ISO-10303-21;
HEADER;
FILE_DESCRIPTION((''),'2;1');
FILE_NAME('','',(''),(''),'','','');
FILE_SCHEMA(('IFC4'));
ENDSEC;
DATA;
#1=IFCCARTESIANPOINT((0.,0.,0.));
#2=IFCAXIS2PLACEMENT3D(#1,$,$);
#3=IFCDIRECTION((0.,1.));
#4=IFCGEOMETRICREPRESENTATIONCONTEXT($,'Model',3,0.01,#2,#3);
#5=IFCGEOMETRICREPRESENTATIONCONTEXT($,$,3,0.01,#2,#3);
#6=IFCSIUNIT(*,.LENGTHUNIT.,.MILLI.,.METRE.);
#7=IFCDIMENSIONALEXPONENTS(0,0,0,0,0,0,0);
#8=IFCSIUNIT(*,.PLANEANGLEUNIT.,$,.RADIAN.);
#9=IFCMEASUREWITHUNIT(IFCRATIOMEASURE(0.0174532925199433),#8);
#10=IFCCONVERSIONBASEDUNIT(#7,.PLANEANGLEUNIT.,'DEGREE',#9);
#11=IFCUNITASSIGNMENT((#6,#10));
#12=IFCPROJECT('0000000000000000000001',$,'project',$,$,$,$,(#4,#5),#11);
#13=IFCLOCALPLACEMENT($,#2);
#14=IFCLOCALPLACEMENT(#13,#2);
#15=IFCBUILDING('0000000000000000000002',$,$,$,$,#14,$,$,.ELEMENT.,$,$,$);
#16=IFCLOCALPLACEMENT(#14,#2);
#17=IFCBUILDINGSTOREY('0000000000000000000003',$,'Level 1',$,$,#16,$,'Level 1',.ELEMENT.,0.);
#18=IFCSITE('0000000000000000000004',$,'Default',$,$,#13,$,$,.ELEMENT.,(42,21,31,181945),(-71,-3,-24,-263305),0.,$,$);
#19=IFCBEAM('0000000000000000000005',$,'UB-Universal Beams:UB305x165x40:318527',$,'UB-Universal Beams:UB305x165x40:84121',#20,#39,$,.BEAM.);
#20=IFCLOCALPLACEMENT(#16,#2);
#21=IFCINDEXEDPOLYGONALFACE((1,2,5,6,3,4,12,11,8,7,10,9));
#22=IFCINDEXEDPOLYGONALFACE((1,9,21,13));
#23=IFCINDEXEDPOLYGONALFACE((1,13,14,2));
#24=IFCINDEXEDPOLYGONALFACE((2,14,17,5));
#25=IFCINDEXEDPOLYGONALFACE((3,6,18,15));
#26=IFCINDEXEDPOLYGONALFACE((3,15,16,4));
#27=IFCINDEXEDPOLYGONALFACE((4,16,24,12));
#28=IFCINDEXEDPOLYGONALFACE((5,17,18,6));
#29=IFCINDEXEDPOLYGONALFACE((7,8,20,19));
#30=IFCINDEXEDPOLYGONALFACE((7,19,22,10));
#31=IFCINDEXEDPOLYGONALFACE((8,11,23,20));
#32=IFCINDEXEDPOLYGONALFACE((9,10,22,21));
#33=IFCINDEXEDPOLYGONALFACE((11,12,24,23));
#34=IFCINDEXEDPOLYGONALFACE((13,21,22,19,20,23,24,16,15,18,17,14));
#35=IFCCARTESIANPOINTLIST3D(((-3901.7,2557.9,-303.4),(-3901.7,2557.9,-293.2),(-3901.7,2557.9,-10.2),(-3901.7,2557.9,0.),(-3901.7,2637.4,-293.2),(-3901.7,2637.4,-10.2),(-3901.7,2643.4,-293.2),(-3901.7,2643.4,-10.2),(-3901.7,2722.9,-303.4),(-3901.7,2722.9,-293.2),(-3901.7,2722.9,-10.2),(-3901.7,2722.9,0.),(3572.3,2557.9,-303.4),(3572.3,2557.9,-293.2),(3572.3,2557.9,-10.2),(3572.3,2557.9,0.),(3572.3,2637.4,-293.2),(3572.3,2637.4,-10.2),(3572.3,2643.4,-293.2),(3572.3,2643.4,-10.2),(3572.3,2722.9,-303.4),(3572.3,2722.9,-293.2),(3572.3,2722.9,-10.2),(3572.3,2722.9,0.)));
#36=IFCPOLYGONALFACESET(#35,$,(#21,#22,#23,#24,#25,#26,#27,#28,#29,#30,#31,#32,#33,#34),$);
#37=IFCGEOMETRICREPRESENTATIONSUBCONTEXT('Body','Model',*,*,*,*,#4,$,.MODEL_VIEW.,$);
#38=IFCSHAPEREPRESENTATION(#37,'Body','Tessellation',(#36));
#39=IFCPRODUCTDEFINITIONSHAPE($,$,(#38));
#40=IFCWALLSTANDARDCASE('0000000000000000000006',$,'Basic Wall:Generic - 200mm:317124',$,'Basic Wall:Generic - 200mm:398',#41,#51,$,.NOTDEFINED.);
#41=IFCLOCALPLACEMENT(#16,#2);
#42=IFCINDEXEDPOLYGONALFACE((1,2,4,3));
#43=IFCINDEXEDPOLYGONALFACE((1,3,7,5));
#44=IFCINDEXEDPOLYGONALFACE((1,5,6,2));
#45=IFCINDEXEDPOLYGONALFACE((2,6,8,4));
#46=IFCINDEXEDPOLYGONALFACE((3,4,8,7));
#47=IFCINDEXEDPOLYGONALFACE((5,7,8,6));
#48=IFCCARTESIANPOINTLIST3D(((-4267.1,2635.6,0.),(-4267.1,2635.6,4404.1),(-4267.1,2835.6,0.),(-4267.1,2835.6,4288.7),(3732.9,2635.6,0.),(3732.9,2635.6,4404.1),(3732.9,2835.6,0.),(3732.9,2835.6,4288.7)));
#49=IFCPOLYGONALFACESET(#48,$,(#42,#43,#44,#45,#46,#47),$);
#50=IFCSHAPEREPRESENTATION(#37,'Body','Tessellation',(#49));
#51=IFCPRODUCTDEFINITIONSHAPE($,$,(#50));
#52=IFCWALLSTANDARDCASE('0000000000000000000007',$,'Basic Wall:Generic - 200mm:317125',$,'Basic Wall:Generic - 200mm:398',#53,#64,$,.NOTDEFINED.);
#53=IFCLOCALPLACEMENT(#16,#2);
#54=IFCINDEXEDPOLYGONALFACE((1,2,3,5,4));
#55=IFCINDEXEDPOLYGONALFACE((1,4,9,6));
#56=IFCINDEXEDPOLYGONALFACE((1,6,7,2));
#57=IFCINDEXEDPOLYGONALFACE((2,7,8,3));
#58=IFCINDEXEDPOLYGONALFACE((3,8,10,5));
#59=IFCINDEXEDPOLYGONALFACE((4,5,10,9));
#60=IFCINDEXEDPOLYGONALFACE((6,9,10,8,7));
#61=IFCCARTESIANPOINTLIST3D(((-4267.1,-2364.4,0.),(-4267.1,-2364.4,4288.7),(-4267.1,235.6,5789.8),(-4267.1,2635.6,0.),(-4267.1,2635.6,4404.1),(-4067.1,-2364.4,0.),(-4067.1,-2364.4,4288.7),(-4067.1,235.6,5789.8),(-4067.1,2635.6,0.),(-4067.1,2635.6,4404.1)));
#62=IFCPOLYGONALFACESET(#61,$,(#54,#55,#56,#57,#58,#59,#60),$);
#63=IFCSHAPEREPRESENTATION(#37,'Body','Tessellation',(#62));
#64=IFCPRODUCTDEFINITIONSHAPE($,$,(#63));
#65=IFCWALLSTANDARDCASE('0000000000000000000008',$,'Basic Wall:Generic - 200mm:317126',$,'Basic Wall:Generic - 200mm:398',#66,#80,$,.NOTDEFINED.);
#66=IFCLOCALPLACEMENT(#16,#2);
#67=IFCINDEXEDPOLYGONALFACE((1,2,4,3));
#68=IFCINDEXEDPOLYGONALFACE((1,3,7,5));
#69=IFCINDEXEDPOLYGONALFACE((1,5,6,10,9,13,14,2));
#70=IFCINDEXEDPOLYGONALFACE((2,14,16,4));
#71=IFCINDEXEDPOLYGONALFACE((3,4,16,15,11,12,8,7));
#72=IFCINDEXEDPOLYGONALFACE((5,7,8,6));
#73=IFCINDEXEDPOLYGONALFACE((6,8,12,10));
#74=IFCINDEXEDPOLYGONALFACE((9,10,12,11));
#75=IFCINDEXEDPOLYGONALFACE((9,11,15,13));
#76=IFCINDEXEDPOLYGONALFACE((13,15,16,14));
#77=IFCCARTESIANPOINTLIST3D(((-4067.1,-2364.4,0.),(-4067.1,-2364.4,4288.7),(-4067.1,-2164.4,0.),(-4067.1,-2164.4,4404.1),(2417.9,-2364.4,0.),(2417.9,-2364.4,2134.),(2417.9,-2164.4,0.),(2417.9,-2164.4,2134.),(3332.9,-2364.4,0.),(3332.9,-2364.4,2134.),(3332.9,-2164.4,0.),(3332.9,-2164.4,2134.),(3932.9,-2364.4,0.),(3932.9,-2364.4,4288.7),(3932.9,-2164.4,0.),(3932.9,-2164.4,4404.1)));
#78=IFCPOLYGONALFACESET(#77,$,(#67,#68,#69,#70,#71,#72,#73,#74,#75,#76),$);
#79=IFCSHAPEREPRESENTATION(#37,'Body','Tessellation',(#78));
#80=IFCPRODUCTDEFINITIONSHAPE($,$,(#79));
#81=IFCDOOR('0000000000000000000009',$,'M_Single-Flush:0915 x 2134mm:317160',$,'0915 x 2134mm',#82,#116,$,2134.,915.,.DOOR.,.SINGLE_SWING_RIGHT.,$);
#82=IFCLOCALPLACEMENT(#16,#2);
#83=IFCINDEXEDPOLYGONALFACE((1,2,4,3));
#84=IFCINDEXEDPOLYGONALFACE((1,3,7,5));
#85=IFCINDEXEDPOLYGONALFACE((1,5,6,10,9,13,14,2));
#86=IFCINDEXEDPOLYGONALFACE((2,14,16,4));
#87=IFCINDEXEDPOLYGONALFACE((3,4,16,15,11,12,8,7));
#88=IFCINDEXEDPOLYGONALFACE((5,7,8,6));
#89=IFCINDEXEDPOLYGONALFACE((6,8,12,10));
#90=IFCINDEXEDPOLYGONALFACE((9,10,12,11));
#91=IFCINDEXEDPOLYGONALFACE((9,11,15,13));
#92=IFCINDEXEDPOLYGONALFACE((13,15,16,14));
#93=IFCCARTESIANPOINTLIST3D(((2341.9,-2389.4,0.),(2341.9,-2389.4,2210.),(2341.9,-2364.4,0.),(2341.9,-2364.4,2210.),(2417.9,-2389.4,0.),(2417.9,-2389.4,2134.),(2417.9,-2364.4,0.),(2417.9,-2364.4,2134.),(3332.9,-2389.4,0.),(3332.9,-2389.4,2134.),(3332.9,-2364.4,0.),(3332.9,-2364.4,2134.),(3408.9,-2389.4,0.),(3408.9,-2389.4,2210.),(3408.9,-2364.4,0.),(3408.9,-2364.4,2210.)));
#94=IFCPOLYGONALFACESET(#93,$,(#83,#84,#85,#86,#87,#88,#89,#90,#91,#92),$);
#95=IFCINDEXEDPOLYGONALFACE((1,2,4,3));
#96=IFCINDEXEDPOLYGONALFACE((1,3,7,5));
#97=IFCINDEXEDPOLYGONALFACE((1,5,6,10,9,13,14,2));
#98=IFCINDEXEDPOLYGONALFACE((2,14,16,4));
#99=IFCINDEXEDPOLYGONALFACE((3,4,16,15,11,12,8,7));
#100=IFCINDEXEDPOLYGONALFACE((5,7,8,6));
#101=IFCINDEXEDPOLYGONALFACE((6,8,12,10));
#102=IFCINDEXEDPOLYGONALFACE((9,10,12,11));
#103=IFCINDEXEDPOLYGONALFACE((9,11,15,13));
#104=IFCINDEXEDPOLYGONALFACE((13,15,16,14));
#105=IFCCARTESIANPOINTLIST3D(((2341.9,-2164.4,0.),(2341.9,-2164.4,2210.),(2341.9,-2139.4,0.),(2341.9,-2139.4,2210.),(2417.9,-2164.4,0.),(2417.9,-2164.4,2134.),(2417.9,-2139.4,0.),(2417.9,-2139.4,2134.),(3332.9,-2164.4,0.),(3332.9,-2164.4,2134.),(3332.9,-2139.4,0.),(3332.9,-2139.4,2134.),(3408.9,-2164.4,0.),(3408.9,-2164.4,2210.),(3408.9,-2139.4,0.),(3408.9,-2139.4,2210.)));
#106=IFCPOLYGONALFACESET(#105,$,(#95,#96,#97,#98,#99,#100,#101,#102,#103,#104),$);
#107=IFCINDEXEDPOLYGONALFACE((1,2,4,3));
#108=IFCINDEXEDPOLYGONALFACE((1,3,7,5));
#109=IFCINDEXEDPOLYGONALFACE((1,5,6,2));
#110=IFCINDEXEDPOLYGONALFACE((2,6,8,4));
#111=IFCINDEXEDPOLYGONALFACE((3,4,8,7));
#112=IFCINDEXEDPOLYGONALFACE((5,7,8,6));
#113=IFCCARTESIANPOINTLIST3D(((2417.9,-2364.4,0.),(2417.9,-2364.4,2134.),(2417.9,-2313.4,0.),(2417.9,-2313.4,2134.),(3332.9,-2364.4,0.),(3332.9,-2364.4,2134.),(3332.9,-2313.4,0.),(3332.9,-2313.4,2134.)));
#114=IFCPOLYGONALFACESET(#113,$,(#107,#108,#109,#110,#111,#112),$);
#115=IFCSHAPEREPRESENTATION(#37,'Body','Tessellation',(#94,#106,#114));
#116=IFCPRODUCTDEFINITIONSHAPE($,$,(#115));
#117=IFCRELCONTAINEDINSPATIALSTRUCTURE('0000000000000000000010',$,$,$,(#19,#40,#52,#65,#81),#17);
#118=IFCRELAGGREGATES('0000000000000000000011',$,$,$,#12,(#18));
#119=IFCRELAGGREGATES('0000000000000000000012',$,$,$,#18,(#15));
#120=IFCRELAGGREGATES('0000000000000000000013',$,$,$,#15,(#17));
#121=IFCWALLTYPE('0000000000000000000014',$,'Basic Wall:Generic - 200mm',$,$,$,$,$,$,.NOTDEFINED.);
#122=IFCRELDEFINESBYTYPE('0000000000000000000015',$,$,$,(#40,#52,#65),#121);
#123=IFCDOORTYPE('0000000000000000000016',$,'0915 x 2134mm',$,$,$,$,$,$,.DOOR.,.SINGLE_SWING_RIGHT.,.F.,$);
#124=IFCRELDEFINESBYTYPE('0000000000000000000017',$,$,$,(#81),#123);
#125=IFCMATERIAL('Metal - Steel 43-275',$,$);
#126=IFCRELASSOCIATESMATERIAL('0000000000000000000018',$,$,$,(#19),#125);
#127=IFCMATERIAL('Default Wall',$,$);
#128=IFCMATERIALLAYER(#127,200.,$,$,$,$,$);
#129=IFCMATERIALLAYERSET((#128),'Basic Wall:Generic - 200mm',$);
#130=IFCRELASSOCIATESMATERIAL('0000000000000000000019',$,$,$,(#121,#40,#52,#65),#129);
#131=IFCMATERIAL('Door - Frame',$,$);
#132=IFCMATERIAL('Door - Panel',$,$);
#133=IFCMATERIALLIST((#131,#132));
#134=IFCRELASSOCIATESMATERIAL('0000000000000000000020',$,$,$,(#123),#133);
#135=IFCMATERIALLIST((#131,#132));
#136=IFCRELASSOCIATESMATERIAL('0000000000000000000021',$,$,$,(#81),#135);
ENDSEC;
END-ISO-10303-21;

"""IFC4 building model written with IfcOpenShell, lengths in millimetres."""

from ifc_helpers import new_model, entity, si_unit, converted_unit, direction, frame, frame_2d, origin, place, context, subcontext, project, spatial, polyline, rectangle, i_section, outline, extrude, clip, bounded_halfspace, source, transform, mapped, material, material_list, layer, layer_set, layer_usage, type_object, type_shapes, element, fill, save


model = new_model("IFC4")

# Units and contexts
model_context = context("Model", 3, precision=0.01, world=origin(), true_north=direction((0.0, 1.0)))
context_of_model = context(None, 3, precision=0.01, world=origin(), true_north=direction((0.0, 1.0)))
body_context = subcontext(model_context, "Body", "Model", "MODEL_VIEW")
ifc_project = project(units=[si_unit("LENGTHUNIT", "METRE", prefix="MILLI"), converted_unit("PLANEANGLEUNIT", "DEGREE", entity("IfcRatioMeasure", 0.0174532925199433), si_unit("PLANEANGLEUNIT", "RADIAN"), dimensions=[0, 0, 0, 0, 0, 0, 0])], contexts=[model_context, context_of_model])

# Site, building, storey
site_placement = place(None, origin())
site = spatial("IfcSite", under=ifc_project, at=site_placement, Name="Default", CompositionType="ELEMENT", RefLatitude=(42, 21, 31, 181945), RefLongitude=(-71, -3, -24, -263305), RefElevation=0.0)
building_placement = place(site_placement, origin())
building = spatial("IfcBuilding", under=site, at=building_placement, CompositionType="ELEMENT")
storey_placement = place(building_placement, origin())
storey = spatial("IfcBuildingStorey", under=building, at=storey_placement, Name="Level 1", LongName="Level 1", CompositionType="ELEMENT", Elevation=0.0)

# Shared definitions
ifc_material_1 = material(Name="Metal - Steel 43-275")

# Beam
beam_1_placement = place(storey_placement, frame((-4067.1, 2640.4, 0.0)))
element("IfcBeam", 1, at=beam_1_placement, inside=storey, material=ifc_material_1, Name="UB-Universal Beams:UB305x165x40:318527", ObjectType="UB-Universal Beams:UB305x165x40:84121", PredefinedType="BEAM", context=body_context, shape_type="SweptSolid", body=[
    extrude(i_section(OverallWidth=165.0, OverallDepth=303.4, WebThickness=6.0, FlangeThickness=10.2, at=frame_2d((0.0, 0.0), x_axis=(0.0, 1.0))), frame((165.4, 0.0, -151.7), z_axis=(1.0, 0.0, 0.0), x_axis=(0.0, 0.0, -1.0)), (0.0, 0.0, 1.0), 7474.0),
])

# Walls
ifc_material_2 = material(Name="Default Wall")
ifc_layer = layer(ifc_material_2, 200.0)
ifc_layer_set = layer_set([ifc_layer], Name="Basic Wall:Generic - 200mm")
ifc_layer_usage_1 = layer_usage(ifc_layer_set, "AXIS2", "NEGATIVE", 100.0)
wall_type = type_object("IfcWallType", Name="Basic Wall:Generic - 200mm", PredefinedType="NOTDEFINED", material=ifc_layer_set)
wall_1_placement = place(storey_placement, frame((-4267.1, 2735.6, 0.0)))
element("IfcWallStandardCase", 2, at=wall_1_placement, inside=storey, type_object=wall_type, material=ifc_layer_usage_1, Name="Basic Wall:Generic - 200mm:317124", ObjectType="Basic Wall:Generic - 200mm:398", PredefinedType="NOTDEFINED", context=body_context, shape_type="Clipping", body=[
    clip(extrude(rectangle(XDim=8000.0, YDim=200.0, at=frame_2d((4000.0, 0.0), x_axis=(-1.0, 0.0))), origin(), (0.0, 0.0, 1.0), 4404.1), bounded_halfspace(frame((0.0, -100.0, 4404.1), z_axis=(0.0, 0.5, 0.866025), x_axis=(-1.0, 0.0, 0.0)), False, frame((0.0, -100.0, 4404.1)), polyline([(0.0, 0.0), (200.0, 0.0), (8000.0, 0.0), (8000.0, 200.0), (0.0, 200.0), (0.0, 0.0)]))),
])
ifc_layer_usage_2 = layer_usage(ifc_layer_set, "AXIS2", "NEGATIVE", 100.0)
wall_2_placement = place(storey_placement, frame((-4167.1, -2364.4, 0.0), z_axis=(0.0, 0.0, 1.0), x_axis=(0.0, 1.0, 0.0)))
element("IfcWallStandardCase", 3, at=wall_2_placement, inside=storey, type_object=wall_type, material=ifc_layer_usage_2, Name="Basic Wall:Generic - 200mm:317125", ObjectType="Basic Wall:Generic - 200mm:398", PredefinedType="NOTDEFINED", context=body_context, shape_type="Clipping", body=[
    clip(clip(extrude(rectangle(XDim=5000.0, YDim=200.0, at=frame_2d((2500.0, 0.0), x_axis=(-1.0, 0.0))), origin(), (0.0, 0.0, 1.0), 5789.8), bounded_halfspace(frame((2600.0, -100.0, 5789.8), z_axis=(0.5, 0.0, 0.866025), x_axis=(0.0, 1.0, 0.0)), False, frame((2600.0, -100.0, 5789.8)), polyline([(0.0, 0.0), (2400.0, 0.0), (2400.0, 200.0), (0.0, 200.0), (0.0, 0.0)]))), bounded_halfspace(frame((0.0, -100.0, 4288.7), z_axis=(-0.5, 0.0, 0.866025), x_axis=(0.0, -1.0, 0.0)), False, frame((0.0, -100.0, 4288.7)), polyline([(0.0, 0.0), (200.0, 0.0), (2600.0, 0.0), (2600.0, 200.0), (0.0, 200.0), (0.0, 0.0)]))),
])

# Wall, opening, door
ifc_layer_usage_3 = layer_usage(ifc_layer_set, "AXIS2", "NEGATIVE", 100.0)
wall_3_placement = place(storey_placement, frame((3932.9, -2264.4, 0.0), z_axis=(0.0, 0.0, 1.0), x_axis=(-1.0, 0.0, 0.0)))
wall_3 = element("IfcWallStandardCase", 4, at=wall_3_placement, inside=storey, type_object=wall_type, material=ifc_layer_usage_3, Name="Basic Wall:Generic - 200mm:317126", ObjectType="Basic Wall:Generic - 200mm:398", PredefinedType="NOTDEFINED", context=body_context, shape_type="Clipping", body=[
    clip(extrude(rectangle(XDim=8000.0, YDim=200.0, at=frame_2d((4000.0, 0.0), x_axis=(-1.0, 0.0))), origin(), (0.0, 0.0, 1.0), 4404.1), bounded_halfspace(frame((0.0, -100.0, 4404.1), z_axis=(0.0, 0.5, 0.866025), x_axis=(-1.0, 0.0, 0.0)), False, frame((0.0, -100.0, 4404.1)), polyline([(0.0, 0.0), (200.0, 0.0), (8000.0, 0.0), (8000.0, 200.0), (0.0, 200.0), (0.0, 0.0)]))),
])
opening_1_placement = place(wall_3_placement, frame((600.0, -100.0, 0.0)))
opening_1 = element("IfcOpeningElement", 5, at=opening_1_placement, cuts=wall_3, ObjectType="Opening", PredefinedType="OPENING", context=body_context, shape_type="SweptSolid", body=[
    extrude(rectangle(XDim=915.0, YDim=2134.0, at=frame_2d((1067.0, 457.5), x_axis=(0.0, 1.0))), frame((0.0, 0.0, 0.0), z_axis=(0.0, 1.0, 0.0), x_axis=(0.0, 0.0, 1.0)), (0.0, 0.0, 1.0), 200.0),
])
ifc_material_3 = material(Name="Door - Frame")
ifc_material_4 = material(Name="Door - Panel")
ifc_material_list_1 = material_list([ifc_material_3, ifc_material_4])
ifc_material_list_2 = material_list([ifc_material_3, ifc_material_4])
door_type = type_object("IfcDoorType", Name="0915 x 2134mm", OperationType="SINGLE_SWING_RIGHT", ParameterTakesPrecedence=False, PredefinedType="DOOR", material=ifc_material_list_2)
shared_shape_1 = source(origin(), body_context, "Body", "SweptSolid", [
    extrude(outline(polyline([(-533.5, -1124.0), (533.5, -1124.0), (533.5, 1086.0), (457.5, 1086.0), (457.5, -1048.0), (-457.5, -1048.0), (-457.5, 1086.0), (-533.5, 1086.0), (-533.5, -1124.0)])), frame((457.5, 200.0, 1086.0), z_axis=(0.0, 1.0, 0.0), x_axis=(1.0, 0.0, 0.0)), (0.0, 0.0, 1.0), 25.0),
    extrude(outline(polyline([(-1124.0, -533.5), (1086.0, -533.5), (1086.0, -457.5), (-1048.0, -457.5), (-1048.0, 457.5), (1086.0, 457.5), (1086.0, 533.5), (-1124.0, 533.5), (-1124.0, -533.5)])), frame((457.5, -25.0, 1086.0), z_axis=(0.0, 1.0, 0.0), x_axis=(0.0, 0.0, -1.0)), (0.0, 0.0, 1.0), 25.0),
    extrude(rectangle(XDim=51.0, YDim=915.0, at=frame_2d((0.0, 0.0), x_axis=(1.0, 0.0))), frame((457.5, 174.5, 0.0), z_axis=(0.0, 0.0, 1.0), x_axis=(0.0, 1.0, 0.0)), (0.0, 0.0, 1.0), 2134.0),
])
type_shapes(door_type, [shared_shape_1])
door_placement = place(opening_1_placement, origin())
door = element("IfcDoor", 6, at=door_placement, inside=storey, type_object=door_type, material=ifc_material_list_1, Name="M_Single-Flush:0915 x 2134mm:317160", ObjectType="0915 x 2134mm", OperationType="SINGLE_SWING_RIGHT", OverallHeight=2134.0, OverallWidth=915.0, PredefinedType="DOOR", context=body_context, shape_type="MappedRepresentation", body=[
    mapped(shared_shape_1, transform((0.0, 0.0, 0.0), scale=1.0)),
])
fill(opening_1, door)

save(model, "model.ifc")
